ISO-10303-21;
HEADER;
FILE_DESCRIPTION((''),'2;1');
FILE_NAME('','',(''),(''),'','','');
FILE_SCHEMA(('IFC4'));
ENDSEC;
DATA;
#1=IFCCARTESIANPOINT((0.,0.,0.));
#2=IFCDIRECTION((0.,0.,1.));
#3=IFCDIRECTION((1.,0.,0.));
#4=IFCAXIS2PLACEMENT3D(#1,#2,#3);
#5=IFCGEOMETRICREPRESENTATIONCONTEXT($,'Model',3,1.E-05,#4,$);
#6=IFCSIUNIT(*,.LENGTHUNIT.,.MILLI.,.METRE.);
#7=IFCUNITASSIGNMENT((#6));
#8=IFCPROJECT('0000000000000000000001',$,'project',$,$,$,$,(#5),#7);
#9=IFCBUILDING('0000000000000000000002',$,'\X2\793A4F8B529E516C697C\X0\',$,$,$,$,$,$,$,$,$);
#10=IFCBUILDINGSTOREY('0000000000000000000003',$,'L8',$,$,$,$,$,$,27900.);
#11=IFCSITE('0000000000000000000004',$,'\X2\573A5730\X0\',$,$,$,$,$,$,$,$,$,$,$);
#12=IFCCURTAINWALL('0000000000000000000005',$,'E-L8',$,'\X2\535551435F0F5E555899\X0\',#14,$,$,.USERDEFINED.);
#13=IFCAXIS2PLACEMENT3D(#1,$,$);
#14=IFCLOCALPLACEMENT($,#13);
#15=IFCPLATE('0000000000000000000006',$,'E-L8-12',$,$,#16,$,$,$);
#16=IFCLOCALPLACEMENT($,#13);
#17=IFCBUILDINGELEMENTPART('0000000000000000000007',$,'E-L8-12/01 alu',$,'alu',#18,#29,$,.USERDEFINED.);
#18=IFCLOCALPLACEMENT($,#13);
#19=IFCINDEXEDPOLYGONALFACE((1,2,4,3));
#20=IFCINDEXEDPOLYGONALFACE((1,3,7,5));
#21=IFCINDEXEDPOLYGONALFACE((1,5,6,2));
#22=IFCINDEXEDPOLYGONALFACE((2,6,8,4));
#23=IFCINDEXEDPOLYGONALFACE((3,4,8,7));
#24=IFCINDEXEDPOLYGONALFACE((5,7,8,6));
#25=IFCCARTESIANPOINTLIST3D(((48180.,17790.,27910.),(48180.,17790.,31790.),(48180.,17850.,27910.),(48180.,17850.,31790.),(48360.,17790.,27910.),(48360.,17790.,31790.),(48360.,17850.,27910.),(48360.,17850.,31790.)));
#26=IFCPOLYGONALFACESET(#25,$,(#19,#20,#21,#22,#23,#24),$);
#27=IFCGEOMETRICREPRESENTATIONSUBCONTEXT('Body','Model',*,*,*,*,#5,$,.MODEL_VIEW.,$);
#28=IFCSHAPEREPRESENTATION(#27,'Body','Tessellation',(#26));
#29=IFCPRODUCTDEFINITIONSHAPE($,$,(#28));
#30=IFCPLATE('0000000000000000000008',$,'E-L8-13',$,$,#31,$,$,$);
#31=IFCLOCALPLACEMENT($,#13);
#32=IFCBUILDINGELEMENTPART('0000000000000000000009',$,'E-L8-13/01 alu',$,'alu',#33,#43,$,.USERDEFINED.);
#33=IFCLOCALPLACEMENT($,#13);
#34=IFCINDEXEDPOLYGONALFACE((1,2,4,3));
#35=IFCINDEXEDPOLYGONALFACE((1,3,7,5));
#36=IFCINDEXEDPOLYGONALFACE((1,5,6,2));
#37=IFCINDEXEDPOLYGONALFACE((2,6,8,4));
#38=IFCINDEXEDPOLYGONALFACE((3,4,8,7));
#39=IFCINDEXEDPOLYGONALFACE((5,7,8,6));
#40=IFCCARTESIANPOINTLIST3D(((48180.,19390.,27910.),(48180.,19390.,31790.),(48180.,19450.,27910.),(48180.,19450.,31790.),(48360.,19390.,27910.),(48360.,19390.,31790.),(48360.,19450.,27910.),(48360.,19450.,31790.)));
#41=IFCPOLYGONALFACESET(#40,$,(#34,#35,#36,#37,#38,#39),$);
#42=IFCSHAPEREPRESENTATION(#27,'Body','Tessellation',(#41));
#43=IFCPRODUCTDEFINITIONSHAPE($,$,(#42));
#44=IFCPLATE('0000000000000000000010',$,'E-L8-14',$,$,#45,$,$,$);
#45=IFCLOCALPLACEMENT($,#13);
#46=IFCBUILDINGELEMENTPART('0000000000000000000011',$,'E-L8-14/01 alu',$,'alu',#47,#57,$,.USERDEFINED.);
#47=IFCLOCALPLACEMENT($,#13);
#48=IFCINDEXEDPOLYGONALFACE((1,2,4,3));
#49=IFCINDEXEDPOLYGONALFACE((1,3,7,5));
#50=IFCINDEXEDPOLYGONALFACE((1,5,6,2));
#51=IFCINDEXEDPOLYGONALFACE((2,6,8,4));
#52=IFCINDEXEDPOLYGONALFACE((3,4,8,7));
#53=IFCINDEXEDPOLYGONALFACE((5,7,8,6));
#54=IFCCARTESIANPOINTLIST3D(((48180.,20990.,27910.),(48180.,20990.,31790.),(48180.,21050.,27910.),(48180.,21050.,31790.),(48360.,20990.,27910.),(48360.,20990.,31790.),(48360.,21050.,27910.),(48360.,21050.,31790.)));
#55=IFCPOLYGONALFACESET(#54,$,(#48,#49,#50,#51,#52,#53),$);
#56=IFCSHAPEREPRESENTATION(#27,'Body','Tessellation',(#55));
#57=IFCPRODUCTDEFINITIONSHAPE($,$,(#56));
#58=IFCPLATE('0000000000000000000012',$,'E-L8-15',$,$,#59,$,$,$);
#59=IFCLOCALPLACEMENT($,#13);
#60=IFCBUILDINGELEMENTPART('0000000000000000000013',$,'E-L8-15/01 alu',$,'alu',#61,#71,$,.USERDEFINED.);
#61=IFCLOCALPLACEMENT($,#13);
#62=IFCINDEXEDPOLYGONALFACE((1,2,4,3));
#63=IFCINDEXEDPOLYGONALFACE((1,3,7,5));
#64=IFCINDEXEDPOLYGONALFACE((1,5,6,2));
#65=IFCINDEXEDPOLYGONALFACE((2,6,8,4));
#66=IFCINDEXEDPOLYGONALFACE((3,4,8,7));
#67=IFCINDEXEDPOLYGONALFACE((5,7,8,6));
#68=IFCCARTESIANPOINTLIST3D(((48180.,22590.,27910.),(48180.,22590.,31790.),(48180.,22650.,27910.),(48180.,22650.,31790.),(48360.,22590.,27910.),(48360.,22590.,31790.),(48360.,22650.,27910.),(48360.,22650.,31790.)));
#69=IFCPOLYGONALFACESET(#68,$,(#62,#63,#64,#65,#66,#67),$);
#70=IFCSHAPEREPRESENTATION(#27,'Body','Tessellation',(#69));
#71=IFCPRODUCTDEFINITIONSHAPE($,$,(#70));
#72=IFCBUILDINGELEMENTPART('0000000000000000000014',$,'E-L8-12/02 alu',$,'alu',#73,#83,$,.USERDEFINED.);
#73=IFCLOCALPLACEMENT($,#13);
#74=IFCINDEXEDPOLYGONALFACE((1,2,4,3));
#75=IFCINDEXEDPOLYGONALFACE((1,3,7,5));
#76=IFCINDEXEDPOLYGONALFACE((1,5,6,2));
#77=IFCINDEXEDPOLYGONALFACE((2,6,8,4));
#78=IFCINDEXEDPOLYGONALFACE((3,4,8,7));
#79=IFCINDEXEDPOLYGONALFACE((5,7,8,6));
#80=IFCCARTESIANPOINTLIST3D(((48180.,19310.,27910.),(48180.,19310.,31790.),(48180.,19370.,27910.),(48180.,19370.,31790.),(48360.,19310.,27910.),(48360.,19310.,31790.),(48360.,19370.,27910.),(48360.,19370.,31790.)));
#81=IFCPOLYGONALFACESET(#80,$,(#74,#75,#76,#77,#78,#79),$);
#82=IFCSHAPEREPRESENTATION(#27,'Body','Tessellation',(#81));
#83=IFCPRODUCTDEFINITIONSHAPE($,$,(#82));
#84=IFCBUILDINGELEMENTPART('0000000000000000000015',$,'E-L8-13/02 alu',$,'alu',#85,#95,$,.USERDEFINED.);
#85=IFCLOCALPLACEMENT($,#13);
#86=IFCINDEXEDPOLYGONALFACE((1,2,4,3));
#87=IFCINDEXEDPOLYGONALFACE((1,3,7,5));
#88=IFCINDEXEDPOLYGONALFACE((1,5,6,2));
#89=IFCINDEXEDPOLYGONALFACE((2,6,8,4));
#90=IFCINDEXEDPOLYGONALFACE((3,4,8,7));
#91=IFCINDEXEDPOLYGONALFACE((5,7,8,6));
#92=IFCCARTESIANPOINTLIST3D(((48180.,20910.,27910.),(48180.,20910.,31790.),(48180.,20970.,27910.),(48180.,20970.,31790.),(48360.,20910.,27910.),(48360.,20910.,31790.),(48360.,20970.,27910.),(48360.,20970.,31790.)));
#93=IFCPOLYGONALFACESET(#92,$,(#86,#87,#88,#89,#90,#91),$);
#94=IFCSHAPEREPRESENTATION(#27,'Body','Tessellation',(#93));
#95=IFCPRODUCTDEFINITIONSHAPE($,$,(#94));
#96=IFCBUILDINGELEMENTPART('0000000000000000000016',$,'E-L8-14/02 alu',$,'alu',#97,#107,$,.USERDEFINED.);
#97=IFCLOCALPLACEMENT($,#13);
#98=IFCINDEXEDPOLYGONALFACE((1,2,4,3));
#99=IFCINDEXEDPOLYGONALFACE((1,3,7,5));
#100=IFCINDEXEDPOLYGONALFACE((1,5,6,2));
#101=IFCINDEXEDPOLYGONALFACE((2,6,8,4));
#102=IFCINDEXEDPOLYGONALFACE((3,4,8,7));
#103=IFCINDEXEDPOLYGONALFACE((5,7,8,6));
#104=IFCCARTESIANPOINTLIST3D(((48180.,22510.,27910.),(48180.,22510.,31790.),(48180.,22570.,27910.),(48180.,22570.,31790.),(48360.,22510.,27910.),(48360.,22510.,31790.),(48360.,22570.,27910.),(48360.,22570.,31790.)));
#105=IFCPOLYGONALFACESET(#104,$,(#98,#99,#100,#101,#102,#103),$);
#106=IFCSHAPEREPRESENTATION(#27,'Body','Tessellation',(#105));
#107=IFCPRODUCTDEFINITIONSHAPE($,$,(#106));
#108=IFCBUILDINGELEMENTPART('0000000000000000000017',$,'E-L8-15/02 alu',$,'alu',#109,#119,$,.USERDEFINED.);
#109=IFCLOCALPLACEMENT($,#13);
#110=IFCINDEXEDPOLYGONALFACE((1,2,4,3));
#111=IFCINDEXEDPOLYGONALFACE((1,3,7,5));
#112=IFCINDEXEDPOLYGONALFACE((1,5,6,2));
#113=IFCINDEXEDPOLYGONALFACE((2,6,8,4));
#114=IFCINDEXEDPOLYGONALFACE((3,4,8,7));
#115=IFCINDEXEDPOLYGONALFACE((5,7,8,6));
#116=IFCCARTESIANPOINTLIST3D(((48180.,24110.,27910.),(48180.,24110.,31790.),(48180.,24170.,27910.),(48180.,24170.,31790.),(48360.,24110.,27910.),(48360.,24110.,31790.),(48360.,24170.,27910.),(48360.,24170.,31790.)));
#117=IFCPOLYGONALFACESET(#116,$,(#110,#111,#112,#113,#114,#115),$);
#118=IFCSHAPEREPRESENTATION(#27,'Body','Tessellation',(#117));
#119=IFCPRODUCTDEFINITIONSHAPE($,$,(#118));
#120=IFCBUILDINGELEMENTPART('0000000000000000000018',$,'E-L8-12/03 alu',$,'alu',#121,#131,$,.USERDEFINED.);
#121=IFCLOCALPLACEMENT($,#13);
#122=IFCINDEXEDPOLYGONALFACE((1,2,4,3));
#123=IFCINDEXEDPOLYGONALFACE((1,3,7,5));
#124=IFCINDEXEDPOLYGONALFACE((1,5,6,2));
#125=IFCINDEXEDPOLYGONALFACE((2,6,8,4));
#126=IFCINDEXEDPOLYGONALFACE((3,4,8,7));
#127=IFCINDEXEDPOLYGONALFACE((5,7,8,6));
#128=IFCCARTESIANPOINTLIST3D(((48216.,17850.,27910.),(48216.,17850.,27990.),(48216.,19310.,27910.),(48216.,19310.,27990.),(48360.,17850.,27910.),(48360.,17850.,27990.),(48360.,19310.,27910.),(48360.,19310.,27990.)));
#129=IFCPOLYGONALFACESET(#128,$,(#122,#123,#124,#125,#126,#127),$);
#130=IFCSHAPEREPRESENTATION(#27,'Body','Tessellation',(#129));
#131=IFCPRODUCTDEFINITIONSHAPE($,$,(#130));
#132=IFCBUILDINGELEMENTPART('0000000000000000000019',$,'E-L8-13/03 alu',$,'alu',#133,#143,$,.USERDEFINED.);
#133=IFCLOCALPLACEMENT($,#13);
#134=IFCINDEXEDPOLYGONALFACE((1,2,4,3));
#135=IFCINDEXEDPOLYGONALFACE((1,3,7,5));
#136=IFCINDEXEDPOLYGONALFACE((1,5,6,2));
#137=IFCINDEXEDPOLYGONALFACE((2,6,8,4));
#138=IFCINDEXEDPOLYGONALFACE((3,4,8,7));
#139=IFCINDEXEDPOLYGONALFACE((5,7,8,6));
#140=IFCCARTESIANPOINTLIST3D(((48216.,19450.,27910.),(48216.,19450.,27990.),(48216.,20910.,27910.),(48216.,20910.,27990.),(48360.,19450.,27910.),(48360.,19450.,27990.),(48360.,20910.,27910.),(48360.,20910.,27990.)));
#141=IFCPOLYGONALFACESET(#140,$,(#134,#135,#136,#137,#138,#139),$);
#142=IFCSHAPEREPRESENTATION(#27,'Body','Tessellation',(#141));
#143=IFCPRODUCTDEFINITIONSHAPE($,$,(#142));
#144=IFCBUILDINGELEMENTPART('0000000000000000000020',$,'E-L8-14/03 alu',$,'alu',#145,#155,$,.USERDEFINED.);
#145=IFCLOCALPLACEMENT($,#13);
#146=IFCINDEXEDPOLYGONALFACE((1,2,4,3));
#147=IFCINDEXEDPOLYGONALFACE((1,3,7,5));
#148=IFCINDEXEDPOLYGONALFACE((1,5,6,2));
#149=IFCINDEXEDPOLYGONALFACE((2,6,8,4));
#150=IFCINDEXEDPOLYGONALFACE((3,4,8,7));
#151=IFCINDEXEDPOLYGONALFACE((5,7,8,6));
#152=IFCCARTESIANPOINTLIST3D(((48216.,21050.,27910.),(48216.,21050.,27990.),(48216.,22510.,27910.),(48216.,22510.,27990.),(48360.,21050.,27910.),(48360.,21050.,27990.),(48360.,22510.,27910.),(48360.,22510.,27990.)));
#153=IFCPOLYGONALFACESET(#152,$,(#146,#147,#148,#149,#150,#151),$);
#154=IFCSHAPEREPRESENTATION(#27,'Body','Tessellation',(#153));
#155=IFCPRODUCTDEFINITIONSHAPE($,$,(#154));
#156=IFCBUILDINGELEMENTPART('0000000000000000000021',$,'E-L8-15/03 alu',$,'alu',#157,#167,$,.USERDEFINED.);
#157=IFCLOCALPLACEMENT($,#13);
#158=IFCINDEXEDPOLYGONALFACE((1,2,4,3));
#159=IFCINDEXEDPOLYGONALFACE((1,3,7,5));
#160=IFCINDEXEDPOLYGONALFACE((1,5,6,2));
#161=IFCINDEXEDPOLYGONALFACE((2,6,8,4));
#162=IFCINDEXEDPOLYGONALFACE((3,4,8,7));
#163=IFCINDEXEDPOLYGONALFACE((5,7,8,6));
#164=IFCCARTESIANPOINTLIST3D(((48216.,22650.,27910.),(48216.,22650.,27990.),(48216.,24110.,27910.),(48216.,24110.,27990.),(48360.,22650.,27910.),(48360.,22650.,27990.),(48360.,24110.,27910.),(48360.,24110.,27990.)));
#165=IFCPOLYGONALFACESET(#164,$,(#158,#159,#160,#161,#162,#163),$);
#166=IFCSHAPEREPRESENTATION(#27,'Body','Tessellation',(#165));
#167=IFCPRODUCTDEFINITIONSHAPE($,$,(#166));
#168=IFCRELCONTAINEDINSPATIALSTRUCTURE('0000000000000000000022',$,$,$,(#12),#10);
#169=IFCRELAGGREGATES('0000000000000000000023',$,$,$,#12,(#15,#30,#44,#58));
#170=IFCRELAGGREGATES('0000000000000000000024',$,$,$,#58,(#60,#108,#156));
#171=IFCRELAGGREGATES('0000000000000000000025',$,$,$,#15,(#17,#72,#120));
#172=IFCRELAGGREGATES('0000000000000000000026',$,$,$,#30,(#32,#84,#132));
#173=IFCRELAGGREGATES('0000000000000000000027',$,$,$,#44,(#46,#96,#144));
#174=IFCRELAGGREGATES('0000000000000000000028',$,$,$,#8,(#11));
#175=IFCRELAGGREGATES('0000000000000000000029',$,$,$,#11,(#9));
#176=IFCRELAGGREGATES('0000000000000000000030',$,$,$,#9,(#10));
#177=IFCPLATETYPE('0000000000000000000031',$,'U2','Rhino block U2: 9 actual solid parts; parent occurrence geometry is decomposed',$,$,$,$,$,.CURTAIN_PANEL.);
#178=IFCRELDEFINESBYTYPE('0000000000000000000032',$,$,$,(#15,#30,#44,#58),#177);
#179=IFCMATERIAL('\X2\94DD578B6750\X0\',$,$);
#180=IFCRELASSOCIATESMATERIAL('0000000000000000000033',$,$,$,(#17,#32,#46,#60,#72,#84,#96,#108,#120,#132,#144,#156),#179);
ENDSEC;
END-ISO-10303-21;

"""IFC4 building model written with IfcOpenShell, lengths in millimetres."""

from ifc_helpers import new_model, si_unit, frame, frame_2d, origin, origin_with_axes, place, context, subcontext, project, spatial, rectangle, extrude, source, transform, mapped, material, type_object, element, aggregate, save


model = new_model("IFC4")

# Units and contexts
model_context = context("Model", 3, precision=1e-05, world=origin_with_axes())
body_context = subcontext(model_context, "Body", "Model", "MODEL_VIEW")
ifc_project = project(units=[si_unit("LENGTHUNIT", "METRE", prefix="MILLI")], contexts=[model_context])

# Site, building, storey
site = spatial("IfcSite", under=ifc_project, Name="场地")
building = spatial("IfcBuilding", under=site, Name="示例办公楼")
storey = spatial("IfcBuildingStorey", under=building, Name="L8", Elevation=27900.0)

# Curtain wall, plates, building element parts
curtain_wall = element("IfcCurtainWall", 1, inside=storey, Name="E-L8", ObjectType="单元式幕墙", PredefinedType="USERDEFINED")
plate_type = type_object("IfcPlateType", Name="U2", Description="Rhino block U2: 9 actual solid parts; parent occurrence geometry is decomposed", PredefinedType="CURTAIN_PANEL")
plate_1_placement = place(None, frame((48360.0, 17790.0, 27910.0), z_axis=(0.0, 0.0, 1.0), x_axis=(0.0, 1.0, 0.0)))
plate_1 = element("IfcPlate", 2, at=plate_1_placement, type_object=plate_type, Name="E-L8-12")
ifc_material_1 = material(Name="铝型材")
shared_shape_1 = source(origin(), body_context, "Body", "SweptSolid", [
    extrude(rectangle(XDim=60.0, YDim=180.0, at=frame_2d((30.0, 90.0))), origin(), (0.0, 0.0, 1.0), 3880.0),
])
building_element_part_1_placement = place(plate_1_placement, origin())
building_element_part_1 = element("IfcBuildingElementPart", 3, at=building_element_part_1_placement, material=ifc_material_1, Name="E-L8-12/01 alu", ObjectType="alu", PredefinedType="USERDEFINED", context=body_context, shape_type="MappedRepresentation", body=[
    mapped(shared_shape_1, transform((0.0, 0.0, 0.0))),
])
plate_2_placement = place(None, frame((48360.0, 19390.0, 27910.0), z_axis=(0.0, 0.0, 1.0), x_axis=(0.0, 1.0, 0.0)))
plate_2 = element("IfcPlate", 4, at=plate_2_placement, type_object=plate_type, Name="E-L8-13")
building_element_part_2_placement = place(plate_2_placement, origin())
building_element_part_2 = element("IfcBuildingElementPart", 5, at=building_element_part_2_placement, material=ifc_material_1, Name="E-L8-13/01 alu", ObjectType="alu", PredefinedType="USERDEFINED", context=body_context, shape_type="MappedRepresentation", body=[
    mapped(shared_shape_1, transform((0.0, 0.0, 0.0))),
])
plate_3_placement = place(None, frame((48360.0, 20990.0, 27910.0), z_axis=(0.0, 0.0, 1.0), x_axis=(0.0, 1.0, 0.0)))
plate_3 = element("IfcPlate", 6, at=plate_3_placement, type_object=plate_type, Name="E-L8-14")
building_element_part_3_placement = place(plate_3_placement, origin())
building_element_part_3 = element("IfcBuildingElementPart", 7, at=building_element_part_3_placement, material=ifc_material_1, Name="E-L8-14/01 alu", ObjectType="alu", PredefinedType="USERDEFINED", context=body_context, shape_type="MappedRepresentation", body=[
    mapped(shared_shape_1, transform((0.0, 0.0, 0.0))),
])
plate_4_placement = place(None, frame((48360.0, 22590.0, 27910.0), z_axis=(0.0, 0.0, 1.0), x_axis=(0.0, 1.0, 0.0)))
plate_4 = element("IfcPlate", 8, at=plate_4_placement, type_object=plate_type, Name="E-L8-15")
aggregate(curtain_wall, [plate_1, plate_2, plate_3, plate_4])
building_element_part_4_placement = place(plate_4_placement, origin())
building_element_part_4 = element("IfcBuildingElementPart", 9, at=building_element_part_4_placement, material=ifc_material_1, Name="E-L8-15/01 alu", ObjectType="alu", PredefinedType="USERDEFINED", context=body_context, shape_type="MappedRepresentation", body=[
    mapped(shared_shape_1, transform((0.0, 0.0, 0.0))),
])
shared_shape_2 = source(origin(), body_context, "Body", "SweptSolid", [
    extrude(rectangle(XDim=60.0, YDim=180.0, at=frame_2d((1550.0, 90.0))), origin(), (0.0, 0.0, 1.0), 3880.0),
])
building_element_part_5_placement = place(plate_1_placement, origin())
building_element_part_5 = element("IfcBuildingElementPart", 10, at=building_element_part_5_placement, material=ifc_material_1, Name="E-L8-12/02 alu", ObjectType="alu", PredefinedType="USERDEFINED", context=body_context, shape_type="MappedRepresentation", body=[
    mapped(shared_shape_2, transform((0.0, 0.0, 0.0))),
])
building_element_part_6_placement = place(plate_2_placement, origin())
building_element_part_6 = element("IfcBuildingElementPart", 11, at=building_element_part_6_placement, material=ifc_material_1, Name="E-L8-13/02 alu", ObjectType="alu", PredefinedType="USERDEFINED", context=body_context, shape_type="MappedRepresentation", body=[
    mapped(shared_shape_2, transform((0.0, 0.0, 0.0))),
])
building_element_part_7_placement = place(plate_3_placement, origin())
building_element_part_7 = element("IfcBuildingElementPart", 12, at=building_element_part_7_placement, material=ifc_material_1, Name="E-L8-14/02 alu", ObjectType="alu", PredefinedType="USERDEFINED", context=body_context, shape_type="MappedRepresentation", body=[
    mapped(shared_shape_2, transform((0.0, 0.0, 0.0))),
])
building_element_part_8_placement = place(plate_4_placement, origin())
building_element_part_8 = element("IfcBuildingElementPart", 13, at=building_element_part_8_placement, material=ifc_material_1, Name="E-L8-15/02 alu", ObjectType="alu", PredefinedType="USERDEFINED", context=body_context, shape_type="MappedRepresentation", body=[
    mapped(shared_shape_2, transform((0.0, 0.0, 0.0))),
])
shared_shape_3 = source(origin(), body_context, "Body", "SweptSolid", [
    extrude(rectangle(XDim=1460.0, YDim=144.0, at=frame_2d((790.0, 72.0))), origin(), (0.0, 0.0, 1.0), 80.0),
])
building_element_part_9_placement = place(plate_1_placement, origin())
building_element_part_9 = element("IfcBuildingElementPart", 14, at=building_element_part_9_placement, material=ifc_material_1, Name="E-L8-12/03 alu", ObjectType="alu", PredefinedType="USERDEFINED", context=body_context, shape_type="MappedRepresentation", body=[
    mapped(shared_shape_3, transform((0.0, 0.0, 0.0))),
])
building_element_part_10_placement = place(plate_2_placement, origin())
building_element_part_10 = element("IfcBuildingElementPart", 15, at=building_element_part_10_placement, material=ifc_material_1, Name="E-L8-13/03 alu", ObjectType="alu", PredefinedType="USERDEFINED", context=body_context, shape_type="MappedRepresentation", body=[
    mapped(shared_shape_3, transform((0.0, 0.0, 0.0))),
])
building_element_part_11_placement = place(plate_3_placement, origin())
building_element_part_11 = element("IfcBuildingElementPart", 16, at=building_element_part_11_placement, material=ifc_material_1, Name="E-L8-14/03 alu", ObjectType="alu", PredefinedType="USERDEFINED", context=body_context, shape_type="MappedRepresentation", body=[
    mapped(shared_shape_3, transform((0.0, 0.0, 0.0))),
])
building_element_part_12_placement = place(plate_4_placement, origin())
building_element_part_12 = element("IfcBuildingElementPart", 17, at=building_element_part_12_placement, material=ifc_material_1, Name="E-L8-15/03 alu", ObjectType="alu", PredefinedType="USERDEFINED", context=body_context, shape_type="MappedRepresentation", body=[
    mapped(shared_shape_3, transform((0.0, 0.0, 0.0))),
])
aggregate(plate_4, [building_element_part_4, building_element_part_8, building_element_part_12])
aggregate(plate_1, [building_element_part_1, building_element_part_5, building_element_part_9])
aggregate(plate_2, [building_element_part_2, building_element_part_6, building_element_part_10])
aggregate(plate_3, [building_element_part_3, building_element_part_7, building_element_part_11])

save(model, "model.ifc")
